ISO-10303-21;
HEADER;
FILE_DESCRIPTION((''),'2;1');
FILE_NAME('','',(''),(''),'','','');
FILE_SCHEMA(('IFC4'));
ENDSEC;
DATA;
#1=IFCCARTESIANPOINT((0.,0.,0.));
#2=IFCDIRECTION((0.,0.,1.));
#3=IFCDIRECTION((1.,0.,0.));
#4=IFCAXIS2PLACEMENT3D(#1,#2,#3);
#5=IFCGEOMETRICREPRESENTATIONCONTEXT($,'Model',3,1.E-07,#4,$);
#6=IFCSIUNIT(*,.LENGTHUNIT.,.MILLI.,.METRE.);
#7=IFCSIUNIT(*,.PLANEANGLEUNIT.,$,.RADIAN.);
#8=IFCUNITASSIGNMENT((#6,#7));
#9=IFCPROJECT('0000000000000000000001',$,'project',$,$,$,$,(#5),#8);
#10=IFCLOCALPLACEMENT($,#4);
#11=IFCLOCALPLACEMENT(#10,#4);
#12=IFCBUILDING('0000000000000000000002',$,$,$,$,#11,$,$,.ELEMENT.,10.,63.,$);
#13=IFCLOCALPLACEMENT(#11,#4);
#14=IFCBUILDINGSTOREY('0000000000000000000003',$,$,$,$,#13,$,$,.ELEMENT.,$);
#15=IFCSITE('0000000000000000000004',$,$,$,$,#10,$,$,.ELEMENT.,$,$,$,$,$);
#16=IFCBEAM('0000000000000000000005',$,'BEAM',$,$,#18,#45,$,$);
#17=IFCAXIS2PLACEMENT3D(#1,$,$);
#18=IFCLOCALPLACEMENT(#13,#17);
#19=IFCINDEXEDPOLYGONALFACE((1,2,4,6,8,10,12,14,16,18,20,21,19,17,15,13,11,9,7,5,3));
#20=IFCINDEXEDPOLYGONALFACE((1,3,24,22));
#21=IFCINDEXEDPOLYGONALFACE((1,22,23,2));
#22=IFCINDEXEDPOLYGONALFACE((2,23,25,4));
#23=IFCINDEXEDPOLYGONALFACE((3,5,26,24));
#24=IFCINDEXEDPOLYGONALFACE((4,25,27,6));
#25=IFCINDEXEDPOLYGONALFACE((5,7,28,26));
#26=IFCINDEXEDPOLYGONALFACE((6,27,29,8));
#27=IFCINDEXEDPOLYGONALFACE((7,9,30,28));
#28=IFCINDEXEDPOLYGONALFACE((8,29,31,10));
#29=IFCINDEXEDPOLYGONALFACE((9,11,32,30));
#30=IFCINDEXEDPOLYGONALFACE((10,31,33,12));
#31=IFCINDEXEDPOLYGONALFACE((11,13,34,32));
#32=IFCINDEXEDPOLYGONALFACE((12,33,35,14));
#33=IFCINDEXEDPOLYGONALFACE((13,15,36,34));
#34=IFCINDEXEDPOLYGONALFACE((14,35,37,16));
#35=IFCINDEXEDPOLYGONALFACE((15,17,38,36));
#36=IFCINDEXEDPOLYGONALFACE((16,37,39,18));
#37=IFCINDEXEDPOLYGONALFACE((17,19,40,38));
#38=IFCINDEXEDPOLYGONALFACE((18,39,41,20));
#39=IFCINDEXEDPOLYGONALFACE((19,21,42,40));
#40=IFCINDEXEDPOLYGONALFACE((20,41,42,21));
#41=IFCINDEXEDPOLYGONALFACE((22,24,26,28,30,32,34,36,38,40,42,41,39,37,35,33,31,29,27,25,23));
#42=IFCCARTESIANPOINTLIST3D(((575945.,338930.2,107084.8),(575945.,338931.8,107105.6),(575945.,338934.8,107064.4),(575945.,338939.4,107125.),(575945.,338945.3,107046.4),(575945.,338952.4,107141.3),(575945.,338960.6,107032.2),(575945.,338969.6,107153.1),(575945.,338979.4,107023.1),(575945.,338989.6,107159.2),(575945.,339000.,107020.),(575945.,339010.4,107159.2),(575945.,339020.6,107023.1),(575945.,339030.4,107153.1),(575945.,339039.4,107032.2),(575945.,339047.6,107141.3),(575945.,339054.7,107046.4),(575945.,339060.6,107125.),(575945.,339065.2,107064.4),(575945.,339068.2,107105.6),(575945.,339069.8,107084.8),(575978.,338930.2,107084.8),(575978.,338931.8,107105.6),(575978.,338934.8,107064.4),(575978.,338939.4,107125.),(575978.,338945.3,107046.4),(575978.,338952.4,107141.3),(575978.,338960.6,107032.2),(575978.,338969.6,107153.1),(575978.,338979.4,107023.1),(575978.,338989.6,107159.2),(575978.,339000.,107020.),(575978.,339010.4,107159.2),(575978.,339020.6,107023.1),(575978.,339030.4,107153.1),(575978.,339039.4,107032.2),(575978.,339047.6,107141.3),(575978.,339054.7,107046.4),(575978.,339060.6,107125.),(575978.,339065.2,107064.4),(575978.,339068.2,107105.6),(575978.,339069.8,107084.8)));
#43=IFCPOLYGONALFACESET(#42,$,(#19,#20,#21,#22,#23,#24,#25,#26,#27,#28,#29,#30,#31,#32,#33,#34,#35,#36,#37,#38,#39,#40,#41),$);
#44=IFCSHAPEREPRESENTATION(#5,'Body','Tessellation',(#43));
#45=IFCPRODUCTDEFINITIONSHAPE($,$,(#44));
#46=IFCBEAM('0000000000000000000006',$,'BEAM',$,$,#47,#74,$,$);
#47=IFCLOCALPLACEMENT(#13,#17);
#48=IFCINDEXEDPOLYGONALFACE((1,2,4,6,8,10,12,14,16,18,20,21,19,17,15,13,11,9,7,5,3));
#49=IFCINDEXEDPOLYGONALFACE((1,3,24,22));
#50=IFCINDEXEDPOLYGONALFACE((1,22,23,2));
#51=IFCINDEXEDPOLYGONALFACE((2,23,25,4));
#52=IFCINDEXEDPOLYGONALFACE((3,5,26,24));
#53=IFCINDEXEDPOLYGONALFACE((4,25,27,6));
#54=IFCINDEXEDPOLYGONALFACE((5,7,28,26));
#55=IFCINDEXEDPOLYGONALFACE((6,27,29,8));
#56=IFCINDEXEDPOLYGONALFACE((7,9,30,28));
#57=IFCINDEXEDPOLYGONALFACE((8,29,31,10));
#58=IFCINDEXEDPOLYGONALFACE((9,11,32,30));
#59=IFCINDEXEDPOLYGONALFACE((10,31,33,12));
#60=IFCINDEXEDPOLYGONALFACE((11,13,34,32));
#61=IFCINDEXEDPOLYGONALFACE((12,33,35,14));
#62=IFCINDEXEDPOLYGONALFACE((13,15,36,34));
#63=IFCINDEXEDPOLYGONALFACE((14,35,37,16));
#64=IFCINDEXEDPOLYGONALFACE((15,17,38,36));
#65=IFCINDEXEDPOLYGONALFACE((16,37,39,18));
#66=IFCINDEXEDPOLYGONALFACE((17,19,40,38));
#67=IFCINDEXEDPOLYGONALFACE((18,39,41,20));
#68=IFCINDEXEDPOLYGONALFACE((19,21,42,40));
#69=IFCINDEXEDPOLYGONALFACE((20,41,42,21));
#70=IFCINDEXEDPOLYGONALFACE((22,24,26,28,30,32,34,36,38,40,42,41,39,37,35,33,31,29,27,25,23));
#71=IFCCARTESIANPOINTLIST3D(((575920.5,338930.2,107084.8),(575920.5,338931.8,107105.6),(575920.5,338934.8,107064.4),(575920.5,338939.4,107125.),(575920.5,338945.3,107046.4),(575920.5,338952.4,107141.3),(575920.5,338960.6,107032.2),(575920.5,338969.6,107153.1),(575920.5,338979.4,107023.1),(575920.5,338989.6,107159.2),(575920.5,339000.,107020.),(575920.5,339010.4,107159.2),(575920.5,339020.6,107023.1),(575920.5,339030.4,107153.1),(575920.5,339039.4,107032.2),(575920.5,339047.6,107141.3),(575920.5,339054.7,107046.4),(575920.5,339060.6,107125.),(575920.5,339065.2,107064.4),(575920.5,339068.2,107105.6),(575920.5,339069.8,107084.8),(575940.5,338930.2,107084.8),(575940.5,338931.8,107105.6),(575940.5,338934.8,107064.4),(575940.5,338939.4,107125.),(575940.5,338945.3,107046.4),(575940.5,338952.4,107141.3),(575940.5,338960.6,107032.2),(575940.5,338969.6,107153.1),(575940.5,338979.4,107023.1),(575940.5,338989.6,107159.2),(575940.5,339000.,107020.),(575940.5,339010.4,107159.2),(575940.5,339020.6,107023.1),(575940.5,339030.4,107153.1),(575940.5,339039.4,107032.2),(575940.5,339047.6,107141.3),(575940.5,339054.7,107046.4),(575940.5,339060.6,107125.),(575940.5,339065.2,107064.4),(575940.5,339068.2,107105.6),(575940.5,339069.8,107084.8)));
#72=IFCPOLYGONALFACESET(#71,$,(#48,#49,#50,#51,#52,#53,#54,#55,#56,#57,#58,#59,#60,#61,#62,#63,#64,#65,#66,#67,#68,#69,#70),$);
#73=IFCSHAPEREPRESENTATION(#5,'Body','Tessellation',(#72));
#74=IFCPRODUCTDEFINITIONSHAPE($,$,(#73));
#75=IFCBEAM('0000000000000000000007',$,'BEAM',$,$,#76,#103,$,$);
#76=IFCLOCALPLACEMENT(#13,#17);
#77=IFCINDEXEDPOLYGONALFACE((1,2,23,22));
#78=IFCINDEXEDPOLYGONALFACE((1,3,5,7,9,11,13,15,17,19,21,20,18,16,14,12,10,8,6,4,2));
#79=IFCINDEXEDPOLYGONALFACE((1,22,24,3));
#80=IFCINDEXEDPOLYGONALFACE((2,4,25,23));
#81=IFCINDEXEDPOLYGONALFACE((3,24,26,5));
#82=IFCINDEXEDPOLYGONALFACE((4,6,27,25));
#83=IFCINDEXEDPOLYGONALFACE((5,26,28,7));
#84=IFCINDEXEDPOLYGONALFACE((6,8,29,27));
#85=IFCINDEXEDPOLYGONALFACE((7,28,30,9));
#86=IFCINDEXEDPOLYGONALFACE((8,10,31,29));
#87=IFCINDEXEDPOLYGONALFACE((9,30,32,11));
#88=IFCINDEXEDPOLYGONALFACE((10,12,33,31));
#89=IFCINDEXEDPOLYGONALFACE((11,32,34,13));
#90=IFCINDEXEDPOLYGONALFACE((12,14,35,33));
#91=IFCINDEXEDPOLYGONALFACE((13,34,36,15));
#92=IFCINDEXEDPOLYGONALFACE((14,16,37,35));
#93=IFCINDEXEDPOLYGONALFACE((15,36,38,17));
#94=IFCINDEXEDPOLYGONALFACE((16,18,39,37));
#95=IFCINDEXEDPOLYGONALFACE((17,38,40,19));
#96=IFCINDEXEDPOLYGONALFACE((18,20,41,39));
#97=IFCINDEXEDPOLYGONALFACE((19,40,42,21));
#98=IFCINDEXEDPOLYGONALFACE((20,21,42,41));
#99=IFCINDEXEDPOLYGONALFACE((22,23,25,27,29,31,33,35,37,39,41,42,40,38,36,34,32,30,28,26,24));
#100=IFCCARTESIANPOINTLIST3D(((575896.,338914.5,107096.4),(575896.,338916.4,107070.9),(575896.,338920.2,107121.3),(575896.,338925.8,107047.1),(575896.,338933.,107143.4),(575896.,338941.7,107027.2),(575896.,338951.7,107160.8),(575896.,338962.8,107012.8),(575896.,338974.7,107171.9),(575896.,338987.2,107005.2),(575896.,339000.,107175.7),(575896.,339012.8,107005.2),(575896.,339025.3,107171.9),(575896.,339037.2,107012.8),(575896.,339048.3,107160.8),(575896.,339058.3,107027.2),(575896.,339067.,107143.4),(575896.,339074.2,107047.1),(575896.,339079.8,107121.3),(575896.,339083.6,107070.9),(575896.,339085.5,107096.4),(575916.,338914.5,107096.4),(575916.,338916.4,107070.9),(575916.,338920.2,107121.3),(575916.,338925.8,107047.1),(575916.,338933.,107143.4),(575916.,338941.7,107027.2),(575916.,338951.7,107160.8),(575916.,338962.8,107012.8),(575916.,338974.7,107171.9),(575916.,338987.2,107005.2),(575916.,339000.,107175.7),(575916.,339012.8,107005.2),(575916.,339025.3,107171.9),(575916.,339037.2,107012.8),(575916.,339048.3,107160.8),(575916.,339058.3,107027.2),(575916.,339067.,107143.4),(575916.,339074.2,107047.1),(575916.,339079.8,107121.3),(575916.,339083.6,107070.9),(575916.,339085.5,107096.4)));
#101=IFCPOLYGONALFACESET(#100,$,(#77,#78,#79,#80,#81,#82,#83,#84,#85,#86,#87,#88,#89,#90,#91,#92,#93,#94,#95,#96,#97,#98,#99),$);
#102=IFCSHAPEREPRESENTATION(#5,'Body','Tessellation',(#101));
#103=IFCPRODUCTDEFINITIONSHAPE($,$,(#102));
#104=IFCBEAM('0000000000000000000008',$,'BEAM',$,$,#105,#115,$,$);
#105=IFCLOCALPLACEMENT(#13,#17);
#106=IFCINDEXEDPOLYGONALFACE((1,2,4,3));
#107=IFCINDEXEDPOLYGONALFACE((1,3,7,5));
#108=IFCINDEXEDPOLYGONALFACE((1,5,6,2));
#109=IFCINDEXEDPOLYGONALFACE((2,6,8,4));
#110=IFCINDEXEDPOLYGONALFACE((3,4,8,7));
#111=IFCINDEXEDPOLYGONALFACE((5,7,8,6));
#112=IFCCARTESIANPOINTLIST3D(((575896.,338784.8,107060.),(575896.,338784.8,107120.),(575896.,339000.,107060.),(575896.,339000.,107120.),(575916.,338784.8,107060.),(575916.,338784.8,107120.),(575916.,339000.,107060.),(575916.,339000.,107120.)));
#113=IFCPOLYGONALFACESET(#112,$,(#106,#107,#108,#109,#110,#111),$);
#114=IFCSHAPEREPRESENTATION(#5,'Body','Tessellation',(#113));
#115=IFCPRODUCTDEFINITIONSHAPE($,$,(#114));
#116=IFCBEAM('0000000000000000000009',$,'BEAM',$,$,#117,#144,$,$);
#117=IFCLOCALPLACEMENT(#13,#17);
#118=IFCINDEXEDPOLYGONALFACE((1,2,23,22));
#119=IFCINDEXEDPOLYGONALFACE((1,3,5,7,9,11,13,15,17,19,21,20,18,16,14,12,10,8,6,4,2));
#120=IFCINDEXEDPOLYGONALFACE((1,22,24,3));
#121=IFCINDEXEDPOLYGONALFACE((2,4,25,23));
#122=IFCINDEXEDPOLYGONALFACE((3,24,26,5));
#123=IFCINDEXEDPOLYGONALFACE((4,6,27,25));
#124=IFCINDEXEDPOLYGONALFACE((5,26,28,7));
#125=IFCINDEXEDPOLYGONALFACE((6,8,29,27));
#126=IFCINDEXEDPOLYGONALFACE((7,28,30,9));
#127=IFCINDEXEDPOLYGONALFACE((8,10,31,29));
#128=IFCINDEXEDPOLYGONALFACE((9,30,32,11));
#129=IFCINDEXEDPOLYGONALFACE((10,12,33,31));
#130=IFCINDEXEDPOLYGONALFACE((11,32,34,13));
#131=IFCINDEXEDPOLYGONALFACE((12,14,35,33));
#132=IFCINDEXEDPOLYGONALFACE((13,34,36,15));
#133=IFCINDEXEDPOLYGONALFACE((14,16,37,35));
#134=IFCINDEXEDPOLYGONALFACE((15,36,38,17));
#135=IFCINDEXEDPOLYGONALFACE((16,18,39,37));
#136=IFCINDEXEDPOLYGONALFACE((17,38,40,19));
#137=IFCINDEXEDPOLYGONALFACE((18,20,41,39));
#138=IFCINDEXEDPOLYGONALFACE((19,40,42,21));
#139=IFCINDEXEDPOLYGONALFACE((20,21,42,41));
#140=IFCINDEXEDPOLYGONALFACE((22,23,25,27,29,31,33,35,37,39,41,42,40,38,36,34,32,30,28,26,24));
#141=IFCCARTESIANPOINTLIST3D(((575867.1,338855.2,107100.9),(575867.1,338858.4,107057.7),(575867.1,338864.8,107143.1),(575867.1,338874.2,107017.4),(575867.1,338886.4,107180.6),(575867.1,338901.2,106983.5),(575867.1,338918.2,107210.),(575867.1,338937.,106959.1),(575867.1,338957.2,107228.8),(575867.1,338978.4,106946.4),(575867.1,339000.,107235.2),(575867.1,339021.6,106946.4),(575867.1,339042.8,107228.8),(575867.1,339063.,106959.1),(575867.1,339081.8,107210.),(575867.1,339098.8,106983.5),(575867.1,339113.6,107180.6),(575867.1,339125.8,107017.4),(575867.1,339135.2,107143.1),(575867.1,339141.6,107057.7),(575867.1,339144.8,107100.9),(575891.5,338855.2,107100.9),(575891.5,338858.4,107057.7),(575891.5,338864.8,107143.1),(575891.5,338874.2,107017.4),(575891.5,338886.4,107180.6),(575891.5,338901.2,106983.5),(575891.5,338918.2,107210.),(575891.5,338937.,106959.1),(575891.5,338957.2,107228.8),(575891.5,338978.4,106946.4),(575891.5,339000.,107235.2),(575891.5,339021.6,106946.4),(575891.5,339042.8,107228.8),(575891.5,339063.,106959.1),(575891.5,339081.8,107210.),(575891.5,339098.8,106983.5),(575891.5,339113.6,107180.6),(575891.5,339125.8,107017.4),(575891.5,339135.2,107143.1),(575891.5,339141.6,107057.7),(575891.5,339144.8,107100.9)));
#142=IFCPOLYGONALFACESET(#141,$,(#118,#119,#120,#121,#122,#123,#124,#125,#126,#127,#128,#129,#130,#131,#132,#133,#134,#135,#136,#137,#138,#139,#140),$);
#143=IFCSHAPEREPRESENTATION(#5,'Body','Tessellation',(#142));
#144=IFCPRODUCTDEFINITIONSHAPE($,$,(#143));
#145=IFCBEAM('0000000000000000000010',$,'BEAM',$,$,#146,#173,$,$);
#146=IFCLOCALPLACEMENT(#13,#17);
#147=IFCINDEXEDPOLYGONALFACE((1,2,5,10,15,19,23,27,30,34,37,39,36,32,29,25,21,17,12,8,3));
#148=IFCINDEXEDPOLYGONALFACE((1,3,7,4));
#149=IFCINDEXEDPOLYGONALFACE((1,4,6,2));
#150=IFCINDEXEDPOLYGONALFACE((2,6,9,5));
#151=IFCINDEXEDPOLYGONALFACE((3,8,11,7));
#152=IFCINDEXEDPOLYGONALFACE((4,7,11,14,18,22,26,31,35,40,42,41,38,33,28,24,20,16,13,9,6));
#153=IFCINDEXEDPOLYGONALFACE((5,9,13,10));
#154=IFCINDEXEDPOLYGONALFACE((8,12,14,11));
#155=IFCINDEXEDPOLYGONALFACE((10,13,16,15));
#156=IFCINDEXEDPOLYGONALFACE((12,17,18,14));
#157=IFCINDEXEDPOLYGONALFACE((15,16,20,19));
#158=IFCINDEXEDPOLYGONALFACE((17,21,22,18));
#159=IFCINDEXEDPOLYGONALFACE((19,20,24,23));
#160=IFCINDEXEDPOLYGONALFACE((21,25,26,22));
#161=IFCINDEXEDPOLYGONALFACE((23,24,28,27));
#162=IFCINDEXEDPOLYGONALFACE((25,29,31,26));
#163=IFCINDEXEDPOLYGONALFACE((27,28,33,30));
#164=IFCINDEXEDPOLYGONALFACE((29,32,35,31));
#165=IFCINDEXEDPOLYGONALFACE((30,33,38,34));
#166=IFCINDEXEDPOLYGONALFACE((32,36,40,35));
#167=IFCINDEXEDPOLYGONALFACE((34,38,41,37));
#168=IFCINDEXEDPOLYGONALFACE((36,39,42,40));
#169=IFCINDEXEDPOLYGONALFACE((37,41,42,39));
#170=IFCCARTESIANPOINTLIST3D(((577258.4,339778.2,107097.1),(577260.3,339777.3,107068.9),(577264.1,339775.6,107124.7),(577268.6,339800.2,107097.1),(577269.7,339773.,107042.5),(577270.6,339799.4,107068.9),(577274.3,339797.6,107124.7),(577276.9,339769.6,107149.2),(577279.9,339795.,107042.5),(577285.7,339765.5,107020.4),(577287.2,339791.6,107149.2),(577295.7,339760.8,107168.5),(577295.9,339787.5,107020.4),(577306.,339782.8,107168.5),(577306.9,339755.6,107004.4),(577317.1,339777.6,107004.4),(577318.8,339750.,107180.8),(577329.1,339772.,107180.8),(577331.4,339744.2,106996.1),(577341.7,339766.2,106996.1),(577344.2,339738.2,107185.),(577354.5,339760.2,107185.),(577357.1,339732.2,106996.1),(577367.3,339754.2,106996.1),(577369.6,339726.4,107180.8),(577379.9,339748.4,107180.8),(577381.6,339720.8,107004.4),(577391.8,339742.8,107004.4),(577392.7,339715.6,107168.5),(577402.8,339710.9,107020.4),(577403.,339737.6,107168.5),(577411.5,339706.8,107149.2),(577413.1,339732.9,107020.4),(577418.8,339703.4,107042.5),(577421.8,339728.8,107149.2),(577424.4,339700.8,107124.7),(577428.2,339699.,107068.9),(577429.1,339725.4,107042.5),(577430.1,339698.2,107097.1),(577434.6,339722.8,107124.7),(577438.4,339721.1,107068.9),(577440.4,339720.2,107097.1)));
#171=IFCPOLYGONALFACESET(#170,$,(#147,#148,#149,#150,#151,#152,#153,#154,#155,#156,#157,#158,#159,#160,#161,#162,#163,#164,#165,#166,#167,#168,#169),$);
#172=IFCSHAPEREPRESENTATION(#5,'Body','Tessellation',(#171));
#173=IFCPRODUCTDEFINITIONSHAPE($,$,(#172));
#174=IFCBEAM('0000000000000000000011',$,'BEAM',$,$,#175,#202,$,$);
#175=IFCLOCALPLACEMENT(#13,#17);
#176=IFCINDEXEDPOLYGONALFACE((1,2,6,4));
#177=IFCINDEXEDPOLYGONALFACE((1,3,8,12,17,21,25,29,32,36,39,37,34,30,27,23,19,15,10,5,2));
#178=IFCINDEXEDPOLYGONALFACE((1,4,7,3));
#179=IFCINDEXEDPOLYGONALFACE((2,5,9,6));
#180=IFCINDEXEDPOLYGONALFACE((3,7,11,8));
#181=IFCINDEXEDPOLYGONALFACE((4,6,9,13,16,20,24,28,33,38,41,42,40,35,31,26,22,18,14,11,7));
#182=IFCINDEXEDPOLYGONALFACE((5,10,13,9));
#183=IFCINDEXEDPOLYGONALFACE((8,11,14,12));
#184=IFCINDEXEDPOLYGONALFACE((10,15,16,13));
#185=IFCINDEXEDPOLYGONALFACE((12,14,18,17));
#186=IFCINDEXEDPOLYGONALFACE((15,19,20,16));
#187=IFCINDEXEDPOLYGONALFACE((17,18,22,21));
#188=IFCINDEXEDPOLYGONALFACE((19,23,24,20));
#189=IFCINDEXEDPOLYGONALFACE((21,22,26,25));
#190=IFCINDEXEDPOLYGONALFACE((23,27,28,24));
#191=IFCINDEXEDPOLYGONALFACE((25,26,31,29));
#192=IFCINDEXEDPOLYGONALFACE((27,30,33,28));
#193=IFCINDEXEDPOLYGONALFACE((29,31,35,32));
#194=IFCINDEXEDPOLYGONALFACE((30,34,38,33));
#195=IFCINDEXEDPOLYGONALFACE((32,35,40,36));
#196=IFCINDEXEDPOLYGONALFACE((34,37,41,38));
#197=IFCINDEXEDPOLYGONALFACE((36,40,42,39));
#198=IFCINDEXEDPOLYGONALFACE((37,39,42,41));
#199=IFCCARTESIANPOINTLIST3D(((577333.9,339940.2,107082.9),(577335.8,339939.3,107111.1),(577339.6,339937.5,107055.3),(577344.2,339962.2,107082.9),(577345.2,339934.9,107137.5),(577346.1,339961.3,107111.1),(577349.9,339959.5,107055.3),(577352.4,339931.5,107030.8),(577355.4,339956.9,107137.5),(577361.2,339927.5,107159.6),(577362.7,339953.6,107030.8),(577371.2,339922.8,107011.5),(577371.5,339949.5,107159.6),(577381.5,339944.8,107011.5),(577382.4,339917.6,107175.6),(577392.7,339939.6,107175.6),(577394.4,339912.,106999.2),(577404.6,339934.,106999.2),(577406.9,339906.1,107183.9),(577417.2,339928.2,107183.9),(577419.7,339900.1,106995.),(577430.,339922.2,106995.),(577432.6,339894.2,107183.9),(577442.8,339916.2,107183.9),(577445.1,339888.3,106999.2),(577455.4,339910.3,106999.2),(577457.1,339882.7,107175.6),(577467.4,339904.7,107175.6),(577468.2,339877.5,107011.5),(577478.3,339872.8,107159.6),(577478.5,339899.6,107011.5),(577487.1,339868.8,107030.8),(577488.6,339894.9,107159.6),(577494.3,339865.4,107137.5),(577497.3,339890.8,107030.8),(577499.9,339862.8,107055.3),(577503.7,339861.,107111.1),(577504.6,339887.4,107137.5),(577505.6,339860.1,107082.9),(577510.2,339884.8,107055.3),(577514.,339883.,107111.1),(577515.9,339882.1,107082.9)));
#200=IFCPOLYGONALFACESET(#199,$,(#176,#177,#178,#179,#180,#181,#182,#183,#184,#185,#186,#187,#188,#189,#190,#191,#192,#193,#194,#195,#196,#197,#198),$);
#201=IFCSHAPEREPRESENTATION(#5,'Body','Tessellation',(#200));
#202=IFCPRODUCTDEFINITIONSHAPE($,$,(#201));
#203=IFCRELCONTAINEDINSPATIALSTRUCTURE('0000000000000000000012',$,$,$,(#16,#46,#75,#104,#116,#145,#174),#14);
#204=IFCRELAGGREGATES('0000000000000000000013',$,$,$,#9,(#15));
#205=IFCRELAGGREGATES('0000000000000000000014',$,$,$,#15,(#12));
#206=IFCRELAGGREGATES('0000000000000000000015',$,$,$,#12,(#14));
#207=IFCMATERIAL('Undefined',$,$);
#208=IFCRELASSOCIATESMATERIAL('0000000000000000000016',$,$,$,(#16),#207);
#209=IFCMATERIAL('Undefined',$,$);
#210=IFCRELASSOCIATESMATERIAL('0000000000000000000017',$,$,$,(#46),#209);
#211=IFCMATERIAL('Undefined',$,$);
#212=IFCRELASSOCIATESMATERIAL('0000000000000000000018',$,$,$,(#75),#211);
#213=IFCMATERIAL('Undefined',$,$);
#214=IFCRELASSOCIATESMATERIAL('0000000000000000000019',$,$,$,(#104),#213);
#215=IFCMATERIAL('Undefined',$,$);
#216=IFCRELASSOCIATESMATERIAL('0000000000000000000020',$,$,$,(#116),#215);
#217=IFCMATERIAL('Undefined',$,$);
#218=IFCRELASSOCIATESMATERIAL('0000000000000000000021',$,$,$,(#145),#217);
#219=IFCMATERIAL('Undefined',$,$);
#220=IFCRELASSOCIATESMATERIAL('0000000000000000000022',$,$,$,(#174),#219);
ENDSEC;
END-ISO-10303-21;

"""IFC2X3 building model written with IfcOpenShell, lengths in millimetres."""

from ifc_helpers import new_model, si_unit, frame, origin_with_axes, origin_2d_with_axis, place, context, project, spatial, rectangle, circle, extrude, material, element, save


model = new_model("IFC2X3")

# Units and contexts
model_context = context("Model", 3, precision=1e-07, world=origin_with_axes())
ifc_project = project(units=[si_unit("LENGTHUNIT", "METRE", prefix="MILLI"), si_unit("PLANEANGLEUNIT", "RADIAN")], contexts=[model_context])

# Site, building, storey
site_placement = place(None, origin_with_axes())
site = spatial("IfcSite", under=ifc_project, at=site_placement, CompositionType="ELEMENT")
building_placement = place(site_placement, origin_with_axes())
building = spatial("IfcBuilding", under=site, at=building_placement, CompositionType="ELEMENT", ElevationOfRefHeight=10.0, ElevationOfTerrain=63.0)
storey_placement = place(building_placement, origin_with_axes())
storey = spatial("IfcBuildingStorey", under=building, at=storey_placement, CompositionType="ELEMENT")

# Beams
ifc_material_1 = material(Name="Undefined")
beam_1_placement = place(storey_placement, frame((575961.5, 339000.0, 107090.0), z_axis=(1.0, 0.0, 0.0), x_axis=(0.0, 1.0, 0.0)))
element("IfcBeam", 1, at=beam_1_placement, inside=storey, material=ifc_material_1, Name="BEAM", context=model_context, shape_type="SweptSolid", body=[
    extrude(circle(Radius=70.0, at=origin_2d_with_axis()), frame((0.0, 0.0, -16.5), z_axis=(0.0, 0.0, 1.0), x_axis=(0.0, -1.0, 0.0)), (0.0, 0.0, 1.0), 33.0),
])
ifc_material_2 = material(Name="Undefined")
beam_2_placement = place(storey_placement, frame((575930.5, 339000.0, 107090.0), z_axis=(1.0, 0.0, 0.0), x_axis=(0.0, 1.0, 0.0)))
element("IfcBeam", 2, at=beam_2_placement, inside=storey, material=ifc_material_2, Name="BEAM", context=model_context, shape_type="SweptSolid", body=[
    extrude(circle(Radius=70.0, at=origin_2d_with_axis()), frame((0.0, 0.0, -10.0), z_axis=(0.0, 0.0, 1.0), x_axis=(0.0, -1.0, 0.0)), (0.0, 0.0, 1.0), 20.0),
])
ifc_material_3 = material(Name="Undefined")
beam_3_placement = place(storey_placement, frame((575906.0, 339000.0, 107090.0), z_axis=(-1.0, 0.0, 0.0), x_axis=(0.0, 1.0, 0.0)))
element("IfcBeam", 3, at=beam_3_placement, inside=storey, material=ifc_material_3, Name="BEAM", context=model_context, shape_type="SweptSolid", body=[
    extrude(circle(Radius=85.7, at=origin_2d_with_axis()), frame((0.0, 0.0, -10.0), z_axis=(0.0, 0.0, 1.0), x_axis=(0.0, -1.0, 0.0)), (0.0, 0.0, 1.0), 20.0),
])
ifc_material_4 = material(Name="Undefined")
beam_4_placement = place(storey_placement, frame((575906.0, 338892.4, 107090.0), z_axis=(0.0, 0.0, 1.0), x_axis=(0.0, -1.0, 0.0)))
element("IfcBeam", 4, at=beam_4_placement, inside=storey, material=ifc_material_4, Name="BEAM", context=model_context, shape_type="SweptSolid", body=[
    extrude(rectangle(XDim=20.0, YDim=215.2, at=origin_2d_with_axis()), frame((0.0, 0.0, -30.0), z_axis=(0.0, 0.0, 1.0), x_axis=(0.0, -1.0, 0.0)), (0.0, 0.0, 1.0), 60.0),
])
ifc_material_5 = material(Name="Undefined")
beam_5_placement = place(storey_placement, frame((575879.3, 339000.0, 107090.0), z_axis=(-1.0, 0.0, 0.0), x_axis=(0.0, 1.0, 0.0)))
element("IfcBeam", 5, at=beam_5_placement, inside=storey, material=ifc_material_5, Name="BEAM", context=model_context, shape_type="SweptSolid", body=[
    extrude(circle(Radius=145.2, at=origin_2d_with_axis()), frame((0.0, 0.0, -12.2), z_axis=(0.0, 0.0, 1.0), x_axis=(0.0, -1.0, 0.0)), (0.0, 0.0, 1.0), 24.4),
])
ifc_material_6 = material(Name="Undefined")
beam_6_placement = place(storey_placement, frame((577349.4, 339749.2, 107090.0), z_axis=(-0.422618, -0.906308, 0.0), x_axis=(-0.906308, 0.422618, 0.0)))
element("IfcBeam", 6, at=beam_6_placement, inside=storey, material=ifc_material_6, Name="BEAM", context=model_context, shape_type="SweptSolid", body=[
    extrude(circle(Radius=95.0, at=origin_2d_with_axis()), frame((0.0, 0.0, -12.2), z_axis=(0.0, 0.0, 1.0), x_axis=(0.0, -1.0, 0.0)), (0.0, 0.0, 1.0), 24.3),
])
ifc_material_7 = material(Name="Undefined")
beam_7_placement = place(storey_placement, frame((577424.9, 339911.2, 107090.0), z_axis=(0.422618, 0.906308, 0.0), x_axis=(-0.906308, 0.422618, 0.0)))
element("IfcBeam", 7, at=beam_7_placement, inside=storey, material=ifc_material_7, Name="BEAM", context=model_context, shape_type="SweptSolid", body=[
    extrude(circle(Radius=95.0, at=origin_2d_with_axis()), frame((0.0, 0.0, -12.2), z_axis=(0.0, 0.0, 1.0), x_axis=(0.0, -1.0, 0.0)), (0.0, 0.0, 1.0), 24.3),
])

save(model, "model.ifc")
